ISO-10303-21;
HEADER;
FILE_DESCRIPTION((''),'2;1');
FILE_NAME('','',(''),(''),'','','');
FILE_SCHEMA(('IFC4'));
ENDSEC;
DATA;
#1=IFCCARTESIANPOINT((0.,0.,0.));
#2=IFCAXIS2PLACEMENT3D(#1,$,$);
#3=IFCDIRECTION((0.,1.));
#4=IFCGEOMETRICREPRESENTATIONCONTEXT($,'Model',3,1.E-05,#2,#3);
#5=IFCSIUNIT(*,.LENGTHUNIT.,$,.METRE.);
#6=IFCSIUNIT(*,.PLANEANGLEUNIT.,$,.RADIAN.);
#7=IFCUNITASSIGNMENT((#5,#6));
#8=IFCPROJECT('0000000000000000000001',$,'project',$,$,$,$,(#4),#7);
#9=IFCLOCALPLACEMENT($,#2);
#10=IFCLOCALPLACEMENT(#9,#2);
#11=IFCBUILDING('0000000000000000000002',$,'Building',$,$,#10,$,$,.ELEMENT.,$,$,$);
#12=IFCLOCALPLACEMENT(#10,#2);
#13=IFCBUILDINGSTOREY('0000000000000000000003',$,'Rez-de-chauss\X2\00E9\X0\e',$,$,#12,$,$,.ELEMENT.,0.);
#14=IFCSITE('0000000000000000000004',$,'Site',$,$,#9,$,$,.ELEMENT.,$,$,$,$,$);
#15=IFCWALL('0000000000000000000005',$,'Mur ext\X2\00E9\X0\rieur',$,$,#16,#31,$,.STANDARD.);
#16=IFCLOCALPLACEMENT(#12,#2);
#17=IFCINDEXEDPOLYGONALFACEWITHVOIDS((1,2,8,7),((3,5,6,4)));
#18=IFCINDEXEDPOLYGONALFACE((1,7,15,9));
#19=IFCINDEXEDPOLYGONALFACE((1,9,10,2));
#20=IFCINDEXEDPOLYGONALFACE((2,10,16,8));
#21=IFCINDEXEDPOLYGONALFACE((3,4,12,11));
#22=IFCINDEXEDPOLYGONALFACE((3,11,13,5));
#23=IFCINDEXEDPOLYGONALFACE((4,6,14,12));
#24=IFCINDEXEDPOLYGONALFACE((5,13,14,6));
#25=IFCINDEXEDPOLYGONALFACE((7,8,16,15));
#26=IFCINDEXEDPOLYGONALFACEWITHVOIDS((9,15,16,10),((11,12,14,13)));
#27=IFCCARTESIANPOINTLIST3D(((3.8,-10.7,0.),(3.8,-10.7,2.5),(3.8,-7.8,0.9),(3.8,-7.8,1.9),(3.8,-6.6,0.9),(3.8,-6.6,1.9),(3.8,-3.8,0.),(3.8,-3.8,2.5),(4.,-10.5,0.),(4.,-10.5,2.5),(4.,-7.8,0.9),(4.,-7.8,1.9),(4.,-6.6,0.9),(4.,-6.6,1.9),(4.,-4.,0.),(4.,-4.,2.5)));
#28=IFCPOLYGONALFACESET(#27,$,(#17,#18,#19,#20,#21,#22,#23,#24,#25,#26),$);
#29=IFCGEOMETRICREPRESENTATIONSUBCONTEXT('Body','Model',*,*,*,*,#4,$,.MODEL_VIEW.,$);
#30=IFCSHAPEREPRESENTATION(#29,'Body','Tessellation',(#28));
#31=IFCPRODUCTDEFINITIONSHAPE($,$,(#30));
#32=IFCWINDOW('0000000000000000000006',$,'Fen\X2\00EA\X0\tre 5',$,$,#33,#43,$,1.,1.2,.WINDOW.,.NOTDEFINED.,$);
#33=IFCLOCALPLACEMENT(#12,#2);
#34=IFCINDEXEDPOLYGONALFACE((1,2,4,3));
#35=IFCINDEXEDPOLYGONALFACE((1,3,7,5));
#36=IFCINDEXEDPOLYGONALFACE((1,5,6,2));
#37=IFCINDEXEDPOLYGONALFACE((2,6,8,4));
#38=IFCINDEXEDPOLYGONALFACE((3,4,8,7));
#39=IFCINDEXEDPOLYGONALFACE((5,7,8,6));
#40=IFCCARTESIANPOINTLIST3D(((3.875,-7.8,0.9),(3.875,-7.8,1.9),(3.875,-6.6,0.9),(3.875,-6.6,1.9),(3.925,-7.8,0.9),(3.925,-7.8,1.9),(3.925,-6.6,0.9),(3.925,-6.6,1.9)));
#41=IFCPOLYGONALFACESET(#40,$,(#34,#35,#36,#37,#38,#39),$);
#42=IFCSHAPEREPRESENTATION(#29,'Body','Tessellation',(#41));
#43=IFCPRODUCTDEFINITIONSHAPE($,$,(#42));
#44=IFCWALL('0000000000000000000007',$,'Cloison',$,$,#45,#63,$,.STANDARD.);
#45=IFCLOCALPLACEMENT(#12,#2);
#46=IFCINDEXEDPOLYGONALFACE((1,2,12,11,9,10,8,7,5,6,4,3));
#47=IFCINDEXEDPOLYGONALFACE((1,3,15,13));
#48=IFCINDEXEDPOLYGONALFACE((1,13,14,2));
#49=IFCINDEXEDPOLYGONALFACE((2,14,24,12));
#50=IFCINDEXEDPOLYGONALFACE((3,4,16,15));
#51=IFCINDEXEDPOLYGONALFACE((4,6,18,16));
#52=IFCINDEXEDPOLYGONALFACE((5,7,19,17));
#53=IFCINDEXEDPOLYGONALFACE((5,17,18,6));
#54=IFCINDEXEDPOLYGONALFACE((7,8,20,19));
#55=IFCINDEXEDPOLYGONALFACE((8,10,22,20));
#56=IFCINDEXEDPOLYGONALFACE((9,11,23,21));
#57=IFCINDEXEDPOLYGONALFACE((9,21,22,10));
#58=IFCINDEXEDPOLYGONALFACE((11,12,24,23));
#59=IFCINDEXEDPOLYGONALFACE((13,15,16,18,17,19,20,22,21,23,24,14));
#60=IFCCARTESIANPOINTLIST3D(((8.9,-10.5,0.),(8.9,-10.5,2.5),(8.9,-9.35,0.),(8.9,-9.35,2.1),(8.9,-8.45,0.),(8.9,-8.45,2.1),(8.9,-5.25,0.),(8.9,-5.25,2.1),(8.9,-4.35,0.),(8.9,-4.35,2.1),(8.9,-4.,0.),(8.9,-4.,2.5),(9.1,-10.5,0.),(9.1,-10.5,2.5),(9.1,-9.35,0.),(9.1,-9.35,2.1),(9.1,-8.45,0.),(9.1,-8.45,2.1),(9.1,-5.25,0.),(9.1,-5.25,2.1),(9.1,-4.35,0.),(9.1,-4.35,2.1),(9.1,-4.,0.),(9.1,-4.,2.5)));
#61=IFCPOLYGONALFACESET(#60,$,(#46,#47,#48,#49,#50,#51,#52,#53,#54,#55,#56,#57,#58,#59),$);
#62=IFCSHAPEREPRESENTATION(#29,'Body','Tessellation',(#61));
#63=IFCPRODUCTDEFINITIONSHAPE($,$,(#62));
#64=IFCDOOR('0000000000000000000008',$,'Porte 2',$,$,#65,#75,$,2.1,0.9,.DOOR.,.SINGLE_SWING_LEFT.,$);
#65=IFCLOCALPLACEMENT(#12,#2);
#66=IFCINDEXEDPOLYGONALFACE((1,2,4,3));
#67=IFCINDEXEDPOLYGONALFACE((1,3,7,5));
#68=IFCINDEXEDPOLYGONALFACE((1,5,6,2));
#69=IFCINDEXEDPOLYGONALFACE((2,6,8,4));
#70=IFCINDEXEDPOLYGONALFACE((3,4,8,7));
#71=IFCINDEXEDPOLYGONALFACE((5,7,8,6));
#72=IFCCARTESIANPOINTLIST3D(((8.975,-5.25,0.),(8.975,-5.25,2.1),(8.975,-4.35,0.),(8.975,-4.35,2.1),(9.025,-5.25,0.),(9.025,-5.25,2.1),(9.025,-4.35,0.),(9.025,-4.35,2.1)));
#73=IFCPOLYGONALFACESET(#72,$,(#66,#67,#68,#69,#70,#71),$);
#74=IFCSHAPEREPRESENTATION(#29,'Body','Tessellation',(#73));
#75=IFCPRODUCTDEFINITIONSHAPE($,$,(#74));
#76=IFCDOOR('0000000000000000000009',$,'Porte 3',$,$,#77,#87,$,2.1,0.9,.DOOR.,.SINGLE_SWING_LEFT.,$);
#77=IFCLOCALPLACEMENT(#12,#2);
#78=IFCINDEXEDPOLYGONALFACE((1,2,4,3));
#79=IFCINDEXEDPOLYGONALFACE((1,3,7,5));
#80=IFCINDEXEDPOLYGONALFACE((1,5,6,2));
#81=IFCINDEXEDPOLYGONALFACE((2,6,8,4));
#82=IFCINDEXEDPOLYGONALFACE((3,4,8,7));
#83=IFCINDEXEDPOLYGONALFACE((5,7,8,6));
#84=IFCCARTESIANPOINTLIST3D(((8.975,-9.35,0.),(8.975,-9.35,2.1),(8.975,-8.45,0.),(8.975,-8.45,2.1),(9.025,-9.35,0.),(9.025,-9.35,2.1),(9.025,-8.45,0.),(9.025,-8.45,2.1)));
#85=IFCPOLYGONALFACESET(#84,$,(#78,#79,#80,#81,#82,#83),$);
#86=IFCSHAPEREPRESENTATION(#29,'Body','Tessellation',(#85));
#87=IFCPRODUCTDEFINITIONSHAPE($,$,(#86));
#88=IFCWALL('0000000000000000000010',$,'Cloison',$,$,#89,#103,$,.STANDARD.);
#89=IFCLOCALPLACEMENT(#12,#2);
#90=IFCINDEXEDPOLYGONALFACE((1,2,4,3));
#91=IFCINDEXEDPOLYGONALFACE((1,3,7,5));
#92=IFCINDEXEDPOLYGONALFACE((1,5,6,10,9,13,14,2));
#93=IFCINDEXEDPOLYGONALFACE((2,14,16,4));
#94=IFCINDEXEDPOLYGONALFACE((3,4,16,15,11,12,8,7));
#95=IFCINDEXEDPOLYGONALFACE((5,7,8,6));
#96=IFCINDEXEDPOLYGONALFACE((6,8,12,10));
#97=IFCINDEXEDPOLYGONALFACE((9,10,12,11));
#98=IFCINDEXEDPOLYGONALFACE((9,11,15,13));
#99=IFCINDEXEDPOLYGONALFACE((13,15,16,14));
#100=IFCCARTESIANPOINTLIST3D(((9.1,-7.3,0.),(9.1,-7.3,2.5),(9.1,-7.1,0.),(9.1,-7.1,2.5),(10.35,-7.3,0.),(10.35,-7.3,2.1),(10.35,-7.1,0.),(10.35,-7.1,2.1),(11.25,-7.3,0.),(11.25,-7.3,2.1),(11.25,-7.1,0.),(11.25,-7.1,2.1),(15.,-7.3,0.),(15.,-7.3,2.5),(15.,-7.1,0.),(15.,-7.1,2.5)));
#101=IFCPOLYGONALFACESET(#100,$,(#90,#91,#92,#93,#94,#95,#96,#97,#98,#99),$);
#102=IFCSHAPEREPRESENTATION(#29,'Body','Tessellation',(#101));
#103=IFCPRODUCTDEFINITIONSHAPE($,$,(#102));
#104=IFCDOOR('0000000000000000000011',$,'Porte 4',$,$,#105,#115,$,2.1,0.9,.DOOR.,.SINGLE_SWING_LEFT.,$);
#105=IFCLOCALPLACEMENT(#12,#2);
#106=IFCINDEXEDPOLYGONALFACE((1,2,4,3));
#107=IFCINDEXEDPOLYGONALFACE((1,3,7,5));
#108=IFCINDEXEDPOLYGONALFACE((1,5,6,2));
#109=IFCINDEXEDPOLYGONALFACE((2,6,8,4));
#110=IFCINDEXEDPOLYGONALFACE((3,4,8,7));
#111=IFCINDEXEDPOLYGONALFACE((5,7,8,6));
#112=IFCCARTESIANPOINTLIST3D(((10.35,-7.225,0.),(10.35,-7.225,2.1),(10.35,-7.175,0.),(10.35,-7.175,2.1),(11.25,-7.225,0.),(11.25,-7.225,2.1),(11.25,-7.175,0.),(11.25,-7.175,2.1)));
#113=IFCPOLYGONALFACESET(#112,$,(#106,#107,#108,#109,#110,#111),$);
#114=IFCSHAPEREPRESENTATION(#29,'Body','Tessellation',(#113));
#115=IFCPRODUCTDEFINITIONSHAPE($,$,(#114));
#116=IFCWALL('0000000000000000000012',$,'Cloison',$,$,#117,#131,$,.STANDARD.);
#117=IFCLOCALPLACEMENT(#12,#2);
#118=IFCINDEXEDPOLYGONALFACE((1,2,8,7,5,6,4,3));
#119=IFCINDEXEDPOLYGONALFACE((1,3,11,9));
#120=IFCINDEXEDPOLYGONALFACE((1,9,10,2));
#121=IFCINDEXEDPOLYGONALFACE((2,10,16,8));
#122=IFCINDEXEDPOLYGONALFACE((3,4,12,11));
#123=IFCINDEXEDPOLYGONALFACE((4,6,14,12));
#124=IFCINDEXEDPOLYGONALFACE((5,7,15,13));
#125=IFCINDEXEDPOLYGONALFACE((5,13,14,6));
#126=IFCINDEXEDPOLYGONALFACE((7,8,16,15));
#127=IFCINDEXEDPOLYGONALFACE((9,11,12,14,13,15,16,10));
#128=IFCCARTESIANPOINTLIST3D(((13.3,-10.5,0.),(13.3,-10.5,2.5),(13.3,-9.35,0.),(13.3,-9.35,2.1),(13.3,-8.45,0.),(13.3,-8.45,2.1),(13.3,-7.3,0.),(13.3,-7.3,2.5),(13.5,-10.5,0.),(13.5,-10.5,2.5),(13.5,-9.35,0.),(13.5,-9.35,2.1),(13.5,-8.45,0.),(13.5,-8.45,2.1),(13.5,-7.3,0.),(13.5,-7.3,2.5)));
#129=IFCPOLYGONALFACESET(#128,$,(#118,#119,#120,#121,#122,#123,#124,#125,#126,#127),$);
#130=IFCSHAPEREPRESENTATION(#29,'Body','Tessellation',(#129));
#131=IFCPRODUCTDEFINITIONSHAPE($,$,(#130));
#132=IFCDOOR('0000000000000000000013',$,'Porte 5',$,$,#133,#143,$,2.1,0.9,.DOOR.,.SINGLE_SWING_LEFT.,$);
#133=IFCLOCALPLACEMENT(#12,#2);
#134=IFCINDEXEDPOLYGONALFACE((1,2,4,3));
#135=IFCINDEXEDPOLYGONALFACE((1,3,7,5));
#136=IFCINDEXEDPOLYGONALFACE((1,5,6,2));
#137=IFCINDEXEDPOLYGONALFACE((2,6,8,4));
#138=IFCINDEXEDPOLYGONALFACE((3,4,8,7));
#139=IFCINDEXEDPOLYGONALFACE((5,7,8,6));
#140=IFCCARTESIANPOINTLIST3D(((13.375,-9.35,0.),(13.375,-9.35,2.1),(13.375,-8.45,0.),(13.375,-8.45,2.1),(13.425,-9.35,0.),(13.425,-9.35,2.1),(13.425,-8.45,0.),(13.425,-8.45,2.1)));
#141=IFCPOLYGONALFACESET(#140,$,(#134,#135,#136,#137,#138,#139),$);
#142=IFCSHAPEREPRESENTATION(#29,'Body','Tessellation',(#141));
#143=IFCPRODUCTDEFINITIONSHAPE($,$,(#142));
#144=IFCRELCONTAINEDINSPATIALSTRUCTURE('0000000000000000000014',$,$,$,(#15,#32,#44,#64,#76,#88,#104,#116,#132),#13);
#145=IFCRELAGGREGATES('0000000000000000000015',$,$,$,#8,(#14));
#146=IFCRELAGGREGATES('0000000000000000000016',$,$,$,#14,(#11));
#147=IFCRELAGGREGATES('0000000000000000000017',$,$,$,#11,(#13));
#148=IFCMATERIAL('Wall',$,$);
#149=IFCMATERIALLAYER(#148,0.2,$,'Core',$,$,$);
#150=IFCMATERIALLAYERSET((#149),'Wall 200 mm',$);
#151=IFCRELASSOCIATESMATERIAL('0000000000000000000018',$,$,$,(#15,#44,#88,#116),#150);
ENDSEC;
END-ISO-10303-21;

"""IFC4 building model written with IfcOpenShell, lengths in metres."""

from ifc_helpers import new_model, si_unit, direction, frame, origin, origin_2d, place, context, subcontext, project, spatial, polyline, rectangle, outline, extrude, material, layer, layer_set, layer_usage, element, fill, save


model = new_model("IFC4")

# Units and contexts
model_context = context("Model", 3, precision=1e-05, world=origin(), true_north=direction((0.0, 1.0)))
body_context = subcontext(model_context, "Body", "Model", "MODEL_VIEW")
ifc_project = project(units=[si_unit("LENGTHUNIT", "METRE"), si_unit("PLANEANGLEUNIT", "RADIAN")], contexts=[model_context])

# Site, building, storey
site_placement = place(None, origin())
site = spatial("IfcSite", under=ifc_project, at=site_placement, Name="Site", CompositionType="ELEMENT")
building_placement = place(site_placement, origin())
building = spatial("IfcBuilding", under=site, at=building_placement, Name="Building", CompositionType="ELEMENT")
storey_placement = place(building_placement, origin())
storey = spatial("IfcBuildingStorey", under=building, at=storey_placement, Name="Rez-de-chaussée", CompositionType="ELEMENT", Elevation=0.0)

# Shared definitions
ifc_material = material(Name="Wall")
ifc_layer = layer(ifc_material, 0.2, Name="Core")
ifc_layer_set = layer_set([ifc_layer], Name="Wall 200 mm")
ifc_layer_usage = layer_usage(ifc_layer_set, "AXIS2", "POSITIVE", -0.1)

# Wall, opening, window
wall_1_placement = place(storey_placement, frame((3.9, -10.6, 0.0), z_axis=(0.0, 0.0, 1.0), x_axis=(0.0, 1.0, 0.0)))
wall_1 = element("IfcWall", 1, at=wall_1_placement, inside=storey, material=ifc_layer_usage, Name="Mur extérieur", PredefinedType="STANDARD", context=body_context, shape_type="SweptSolid", body=[
    extrude(outline(polyline([(0.0, 0.0), (0.1, -0.1), (6.6, -0.1), (6.7, 0.0), (6.8, 0.1), (-0.1, 0.1), (0.0, 0.0)])), origin(), (0.0, 0.0, 1.0), 2.5),
])
opening_1_placement = place(wall_1_placement, frame((3.4, 0.0, 0.9)))
opening_1 = element("IfcOpeningElement", 2, at=opening_1_placement, cuts=wall_1, PredefinedType="OPENING", context=body_context, shape_type="SweptSolid", body=[
    extrude(rectangle(XDim=1.2, YDim=0.4, at=origin_2d()), origin(), (0.0, 0.0, 1.0), 1.0),
])
window_1_placement = place(opening_1_placement, origin())
window_1 = element("IfcWindow", 3, at=window_1_placement, inside=storey, Name="Fenêtre 5", OverallHeight=1.0, OverallWidth=1.2, PartitioningType="NOTDEFINED", PredefinedType="WINDOW", context=body_context, shape_type="SweptSolid", body=[
    extrude(rectangle(XDim=1.2, YDim=0.05, at=origin_2d()), origin(), (0.0, 0.0, 1.0), 1.0),
])
fill(opening_1, window_1)

# Wall, openings, doors
wall_2_placement = place(storey_placement, frame((9.0, -3.9, 0.0), z_axis=(0.0, 0.0, 1.0), x_axis=(0.0, -1.0, 0.0)))
wall_2 = element("IfcWall", 4, at=wall_2_placement, inside=storey, material=ifc_layer_usage, Name="Cloison", PredefinedType="STANDARD", context=body_context, shape_type="SweptSolid", body=[
    extrude(outline(polyline([(0.1, 0.0), (0.1, -0.1), (6.6, -0.1), (6.6, 0.0), (6.6, 0.1), (0.1, 0.1), (0.1, 0.0)])), origin(), (0.0, 0.0, 1.0), 2.5),
])
opening_2_placement = place(wall_2_placement, frame((0.9, 0.0, 0.0)))
opening_2 = element("IfcOpeningElement", 5, at=opening_2_placement, cuts=wall_2, PredefinedType="OPENING", context=body_context, shape_type="SweptSolid", body=[
    extrude(rectangle(XDim=0.9, YDim=0.4, at=origin_2d()), origin(), (0.0, 0.0, 1.0), 2.1),
])
opening_3_placement = place(wall_2_placement, frame((5.0, 0.0, 0.0)))
opening_3 = element("IfcOpeningElement", 6, at=opening_3_placement, cuts=wall_2, PredefinedType="OPENING", context=body_context, shape_type="SweptSolid", body=[
    extrude(rectangle(XDim=0.9, YDim=0.4, at=origin_2d()), origin(), (0.0, 0.0, 1.0), 2.1),
])
door_1_placement = place(opening_2_placement, origin())
door_1 = element("IfcDoor", 7, at=door_1_placement, inside=storey, Name="Porte 2", OperationType="SINGLE_SWING_LEFT", OverallHeight=2.1, OverallWidth=0.9, PredefinedType="DOOR", context=body_context, shape_type="SweptSolid", body=[
    extrude(rectangle(XDim=0.9, YDim=0.05, at=origin_2d()), origin(), (0.0, 0.0, 1.0), 2.1),
])
fill(opening_2, door_1)
door_2_placement = place(opening_3_placement, origin())
door_2 = element("IfcDoor", 8, at=door_2_placement, inside=storey, Name="Porte 3", OperationType="SINGLE_SWING_LEFT", OverallHeight=2.1, OverallWidth=0.9, PredefinedType="DOOR", context=body_context, shape_type="SweptSolid", body=[
    extrude(rectangle(XDim=0.9, YDim=0.05, at=origin_2d()), origin(), (0.0, 0.0, 1.0), 2.1),
])
fill(opening_3, door_2)

# Walls, openings, doors
wall_3_placement = place(storey_placement, frame((9.0, -7.2, 0.0)))
wall_3 = element("IfcWall", 9, at=wall_3_placement, inside=storey, material=ifc_layer_usage, Name="Cloison", PredefinedType="STANDARD", context=body_context, shape_type="SweptSolid", body=[
    extrude(outline(polyline([(0.1, 0.0), (0.1, -0.1), (6.0, -0.1), (6.0, 0.0), (6.0, 0.1), (0.1, 0.1), (0.1, 0.0)])), origin(), (0.0, 0.0, 1.0), 2.5),
])
opening_4_placement = place(wall_3_placement, frame((1.8, 0.0, 0.0)))
opening_4 = element("IfcOpeningElement", 10, at=opening_4_placement, cuts=wall_3, PredefinedType="OPENING", context=body_context, shape_type="SweptSolid", body=[
    extrude(rectangle(XDim=0.9, YDim=0.4, at=origin_2d()), origin(), (0.0, 0.0, 1.0), 2.1),
])
door_3_placement = place(opening_4_placement, origin())
door_3 = element("IfcDoor", 11, at=door_3_placement, inside=storey, Name="Porte 4", OperationType="SINGLE_SWING_LEFT", OverallHeight=2.1, OverallWidth=0.9, PredefinedType="DOOR", context=body_context, shape_type="SweptSolid", body=[
    extrude(rectangle(XDim=0.9, YDim=0.05, at=origin_2d()), origin(), (0.0, 0.0, 1.0), 2.1),
])
fill(opening_4, door_3)
wall_4_placement = place(storey_placement, frame((13.4, -7.2, 0.0), z_axis=(0.0, 0.0, 1.0), x_axis=(0.0, -1.0, 0.0)))
wall_4 = element("IfcWall", 12, at=wall_4_placement, inside=storey, material=ifc_layer_usage, Name="Cloison", PredefinedType="STANDARD", context=body_context, shape_type="SweptSolid", body=[
    extrude(outline(polyline([(0.1, 0.0), (0.1, -0.1), (3.3, -0.1), (3.3, 0.0), (3.3, 0.1), (0.1, 0.1), (0.1, 0.0)])), origin(), (0.0, 0.0, 1.0), 2.5),
])
opening_5_placement = place(wall_4_placement, frame((1.7, 0.0, 0.0)))
opening_5 = element("IfcOpeningElement", 13, at=opening_5_placement, cuts=wall_4, PredefinedType="OPENING", context=body_context, shape_type="SweptSolid", body=[
    extrude(rectangle(XDim=0.9, YDim=0.4, at=origin_2d()), origin(), (0.0, 0.0, 1.0), 2.1),
])
door_4_placement = place(opening_5_placement, origin())
door_4 = element("IfcDoor", 14, at=door_4_placement, inside=storey, Name="Porte 5", OperationType="SINGLE_SWING_LEFT", OverallHeight=2.1, OverallWidth=0.9, PredefinedType="DOOR", context=body_context, shape_type="SweptSolid", body=[
    extrude(rectangle(XDim=0.9, YDim=0.05, at=origin_2d()), origin(), (0.0, 0.0, 1.0), 2.1),
])
fill(opening_5, door_4)

save(model, "model.ifc")
